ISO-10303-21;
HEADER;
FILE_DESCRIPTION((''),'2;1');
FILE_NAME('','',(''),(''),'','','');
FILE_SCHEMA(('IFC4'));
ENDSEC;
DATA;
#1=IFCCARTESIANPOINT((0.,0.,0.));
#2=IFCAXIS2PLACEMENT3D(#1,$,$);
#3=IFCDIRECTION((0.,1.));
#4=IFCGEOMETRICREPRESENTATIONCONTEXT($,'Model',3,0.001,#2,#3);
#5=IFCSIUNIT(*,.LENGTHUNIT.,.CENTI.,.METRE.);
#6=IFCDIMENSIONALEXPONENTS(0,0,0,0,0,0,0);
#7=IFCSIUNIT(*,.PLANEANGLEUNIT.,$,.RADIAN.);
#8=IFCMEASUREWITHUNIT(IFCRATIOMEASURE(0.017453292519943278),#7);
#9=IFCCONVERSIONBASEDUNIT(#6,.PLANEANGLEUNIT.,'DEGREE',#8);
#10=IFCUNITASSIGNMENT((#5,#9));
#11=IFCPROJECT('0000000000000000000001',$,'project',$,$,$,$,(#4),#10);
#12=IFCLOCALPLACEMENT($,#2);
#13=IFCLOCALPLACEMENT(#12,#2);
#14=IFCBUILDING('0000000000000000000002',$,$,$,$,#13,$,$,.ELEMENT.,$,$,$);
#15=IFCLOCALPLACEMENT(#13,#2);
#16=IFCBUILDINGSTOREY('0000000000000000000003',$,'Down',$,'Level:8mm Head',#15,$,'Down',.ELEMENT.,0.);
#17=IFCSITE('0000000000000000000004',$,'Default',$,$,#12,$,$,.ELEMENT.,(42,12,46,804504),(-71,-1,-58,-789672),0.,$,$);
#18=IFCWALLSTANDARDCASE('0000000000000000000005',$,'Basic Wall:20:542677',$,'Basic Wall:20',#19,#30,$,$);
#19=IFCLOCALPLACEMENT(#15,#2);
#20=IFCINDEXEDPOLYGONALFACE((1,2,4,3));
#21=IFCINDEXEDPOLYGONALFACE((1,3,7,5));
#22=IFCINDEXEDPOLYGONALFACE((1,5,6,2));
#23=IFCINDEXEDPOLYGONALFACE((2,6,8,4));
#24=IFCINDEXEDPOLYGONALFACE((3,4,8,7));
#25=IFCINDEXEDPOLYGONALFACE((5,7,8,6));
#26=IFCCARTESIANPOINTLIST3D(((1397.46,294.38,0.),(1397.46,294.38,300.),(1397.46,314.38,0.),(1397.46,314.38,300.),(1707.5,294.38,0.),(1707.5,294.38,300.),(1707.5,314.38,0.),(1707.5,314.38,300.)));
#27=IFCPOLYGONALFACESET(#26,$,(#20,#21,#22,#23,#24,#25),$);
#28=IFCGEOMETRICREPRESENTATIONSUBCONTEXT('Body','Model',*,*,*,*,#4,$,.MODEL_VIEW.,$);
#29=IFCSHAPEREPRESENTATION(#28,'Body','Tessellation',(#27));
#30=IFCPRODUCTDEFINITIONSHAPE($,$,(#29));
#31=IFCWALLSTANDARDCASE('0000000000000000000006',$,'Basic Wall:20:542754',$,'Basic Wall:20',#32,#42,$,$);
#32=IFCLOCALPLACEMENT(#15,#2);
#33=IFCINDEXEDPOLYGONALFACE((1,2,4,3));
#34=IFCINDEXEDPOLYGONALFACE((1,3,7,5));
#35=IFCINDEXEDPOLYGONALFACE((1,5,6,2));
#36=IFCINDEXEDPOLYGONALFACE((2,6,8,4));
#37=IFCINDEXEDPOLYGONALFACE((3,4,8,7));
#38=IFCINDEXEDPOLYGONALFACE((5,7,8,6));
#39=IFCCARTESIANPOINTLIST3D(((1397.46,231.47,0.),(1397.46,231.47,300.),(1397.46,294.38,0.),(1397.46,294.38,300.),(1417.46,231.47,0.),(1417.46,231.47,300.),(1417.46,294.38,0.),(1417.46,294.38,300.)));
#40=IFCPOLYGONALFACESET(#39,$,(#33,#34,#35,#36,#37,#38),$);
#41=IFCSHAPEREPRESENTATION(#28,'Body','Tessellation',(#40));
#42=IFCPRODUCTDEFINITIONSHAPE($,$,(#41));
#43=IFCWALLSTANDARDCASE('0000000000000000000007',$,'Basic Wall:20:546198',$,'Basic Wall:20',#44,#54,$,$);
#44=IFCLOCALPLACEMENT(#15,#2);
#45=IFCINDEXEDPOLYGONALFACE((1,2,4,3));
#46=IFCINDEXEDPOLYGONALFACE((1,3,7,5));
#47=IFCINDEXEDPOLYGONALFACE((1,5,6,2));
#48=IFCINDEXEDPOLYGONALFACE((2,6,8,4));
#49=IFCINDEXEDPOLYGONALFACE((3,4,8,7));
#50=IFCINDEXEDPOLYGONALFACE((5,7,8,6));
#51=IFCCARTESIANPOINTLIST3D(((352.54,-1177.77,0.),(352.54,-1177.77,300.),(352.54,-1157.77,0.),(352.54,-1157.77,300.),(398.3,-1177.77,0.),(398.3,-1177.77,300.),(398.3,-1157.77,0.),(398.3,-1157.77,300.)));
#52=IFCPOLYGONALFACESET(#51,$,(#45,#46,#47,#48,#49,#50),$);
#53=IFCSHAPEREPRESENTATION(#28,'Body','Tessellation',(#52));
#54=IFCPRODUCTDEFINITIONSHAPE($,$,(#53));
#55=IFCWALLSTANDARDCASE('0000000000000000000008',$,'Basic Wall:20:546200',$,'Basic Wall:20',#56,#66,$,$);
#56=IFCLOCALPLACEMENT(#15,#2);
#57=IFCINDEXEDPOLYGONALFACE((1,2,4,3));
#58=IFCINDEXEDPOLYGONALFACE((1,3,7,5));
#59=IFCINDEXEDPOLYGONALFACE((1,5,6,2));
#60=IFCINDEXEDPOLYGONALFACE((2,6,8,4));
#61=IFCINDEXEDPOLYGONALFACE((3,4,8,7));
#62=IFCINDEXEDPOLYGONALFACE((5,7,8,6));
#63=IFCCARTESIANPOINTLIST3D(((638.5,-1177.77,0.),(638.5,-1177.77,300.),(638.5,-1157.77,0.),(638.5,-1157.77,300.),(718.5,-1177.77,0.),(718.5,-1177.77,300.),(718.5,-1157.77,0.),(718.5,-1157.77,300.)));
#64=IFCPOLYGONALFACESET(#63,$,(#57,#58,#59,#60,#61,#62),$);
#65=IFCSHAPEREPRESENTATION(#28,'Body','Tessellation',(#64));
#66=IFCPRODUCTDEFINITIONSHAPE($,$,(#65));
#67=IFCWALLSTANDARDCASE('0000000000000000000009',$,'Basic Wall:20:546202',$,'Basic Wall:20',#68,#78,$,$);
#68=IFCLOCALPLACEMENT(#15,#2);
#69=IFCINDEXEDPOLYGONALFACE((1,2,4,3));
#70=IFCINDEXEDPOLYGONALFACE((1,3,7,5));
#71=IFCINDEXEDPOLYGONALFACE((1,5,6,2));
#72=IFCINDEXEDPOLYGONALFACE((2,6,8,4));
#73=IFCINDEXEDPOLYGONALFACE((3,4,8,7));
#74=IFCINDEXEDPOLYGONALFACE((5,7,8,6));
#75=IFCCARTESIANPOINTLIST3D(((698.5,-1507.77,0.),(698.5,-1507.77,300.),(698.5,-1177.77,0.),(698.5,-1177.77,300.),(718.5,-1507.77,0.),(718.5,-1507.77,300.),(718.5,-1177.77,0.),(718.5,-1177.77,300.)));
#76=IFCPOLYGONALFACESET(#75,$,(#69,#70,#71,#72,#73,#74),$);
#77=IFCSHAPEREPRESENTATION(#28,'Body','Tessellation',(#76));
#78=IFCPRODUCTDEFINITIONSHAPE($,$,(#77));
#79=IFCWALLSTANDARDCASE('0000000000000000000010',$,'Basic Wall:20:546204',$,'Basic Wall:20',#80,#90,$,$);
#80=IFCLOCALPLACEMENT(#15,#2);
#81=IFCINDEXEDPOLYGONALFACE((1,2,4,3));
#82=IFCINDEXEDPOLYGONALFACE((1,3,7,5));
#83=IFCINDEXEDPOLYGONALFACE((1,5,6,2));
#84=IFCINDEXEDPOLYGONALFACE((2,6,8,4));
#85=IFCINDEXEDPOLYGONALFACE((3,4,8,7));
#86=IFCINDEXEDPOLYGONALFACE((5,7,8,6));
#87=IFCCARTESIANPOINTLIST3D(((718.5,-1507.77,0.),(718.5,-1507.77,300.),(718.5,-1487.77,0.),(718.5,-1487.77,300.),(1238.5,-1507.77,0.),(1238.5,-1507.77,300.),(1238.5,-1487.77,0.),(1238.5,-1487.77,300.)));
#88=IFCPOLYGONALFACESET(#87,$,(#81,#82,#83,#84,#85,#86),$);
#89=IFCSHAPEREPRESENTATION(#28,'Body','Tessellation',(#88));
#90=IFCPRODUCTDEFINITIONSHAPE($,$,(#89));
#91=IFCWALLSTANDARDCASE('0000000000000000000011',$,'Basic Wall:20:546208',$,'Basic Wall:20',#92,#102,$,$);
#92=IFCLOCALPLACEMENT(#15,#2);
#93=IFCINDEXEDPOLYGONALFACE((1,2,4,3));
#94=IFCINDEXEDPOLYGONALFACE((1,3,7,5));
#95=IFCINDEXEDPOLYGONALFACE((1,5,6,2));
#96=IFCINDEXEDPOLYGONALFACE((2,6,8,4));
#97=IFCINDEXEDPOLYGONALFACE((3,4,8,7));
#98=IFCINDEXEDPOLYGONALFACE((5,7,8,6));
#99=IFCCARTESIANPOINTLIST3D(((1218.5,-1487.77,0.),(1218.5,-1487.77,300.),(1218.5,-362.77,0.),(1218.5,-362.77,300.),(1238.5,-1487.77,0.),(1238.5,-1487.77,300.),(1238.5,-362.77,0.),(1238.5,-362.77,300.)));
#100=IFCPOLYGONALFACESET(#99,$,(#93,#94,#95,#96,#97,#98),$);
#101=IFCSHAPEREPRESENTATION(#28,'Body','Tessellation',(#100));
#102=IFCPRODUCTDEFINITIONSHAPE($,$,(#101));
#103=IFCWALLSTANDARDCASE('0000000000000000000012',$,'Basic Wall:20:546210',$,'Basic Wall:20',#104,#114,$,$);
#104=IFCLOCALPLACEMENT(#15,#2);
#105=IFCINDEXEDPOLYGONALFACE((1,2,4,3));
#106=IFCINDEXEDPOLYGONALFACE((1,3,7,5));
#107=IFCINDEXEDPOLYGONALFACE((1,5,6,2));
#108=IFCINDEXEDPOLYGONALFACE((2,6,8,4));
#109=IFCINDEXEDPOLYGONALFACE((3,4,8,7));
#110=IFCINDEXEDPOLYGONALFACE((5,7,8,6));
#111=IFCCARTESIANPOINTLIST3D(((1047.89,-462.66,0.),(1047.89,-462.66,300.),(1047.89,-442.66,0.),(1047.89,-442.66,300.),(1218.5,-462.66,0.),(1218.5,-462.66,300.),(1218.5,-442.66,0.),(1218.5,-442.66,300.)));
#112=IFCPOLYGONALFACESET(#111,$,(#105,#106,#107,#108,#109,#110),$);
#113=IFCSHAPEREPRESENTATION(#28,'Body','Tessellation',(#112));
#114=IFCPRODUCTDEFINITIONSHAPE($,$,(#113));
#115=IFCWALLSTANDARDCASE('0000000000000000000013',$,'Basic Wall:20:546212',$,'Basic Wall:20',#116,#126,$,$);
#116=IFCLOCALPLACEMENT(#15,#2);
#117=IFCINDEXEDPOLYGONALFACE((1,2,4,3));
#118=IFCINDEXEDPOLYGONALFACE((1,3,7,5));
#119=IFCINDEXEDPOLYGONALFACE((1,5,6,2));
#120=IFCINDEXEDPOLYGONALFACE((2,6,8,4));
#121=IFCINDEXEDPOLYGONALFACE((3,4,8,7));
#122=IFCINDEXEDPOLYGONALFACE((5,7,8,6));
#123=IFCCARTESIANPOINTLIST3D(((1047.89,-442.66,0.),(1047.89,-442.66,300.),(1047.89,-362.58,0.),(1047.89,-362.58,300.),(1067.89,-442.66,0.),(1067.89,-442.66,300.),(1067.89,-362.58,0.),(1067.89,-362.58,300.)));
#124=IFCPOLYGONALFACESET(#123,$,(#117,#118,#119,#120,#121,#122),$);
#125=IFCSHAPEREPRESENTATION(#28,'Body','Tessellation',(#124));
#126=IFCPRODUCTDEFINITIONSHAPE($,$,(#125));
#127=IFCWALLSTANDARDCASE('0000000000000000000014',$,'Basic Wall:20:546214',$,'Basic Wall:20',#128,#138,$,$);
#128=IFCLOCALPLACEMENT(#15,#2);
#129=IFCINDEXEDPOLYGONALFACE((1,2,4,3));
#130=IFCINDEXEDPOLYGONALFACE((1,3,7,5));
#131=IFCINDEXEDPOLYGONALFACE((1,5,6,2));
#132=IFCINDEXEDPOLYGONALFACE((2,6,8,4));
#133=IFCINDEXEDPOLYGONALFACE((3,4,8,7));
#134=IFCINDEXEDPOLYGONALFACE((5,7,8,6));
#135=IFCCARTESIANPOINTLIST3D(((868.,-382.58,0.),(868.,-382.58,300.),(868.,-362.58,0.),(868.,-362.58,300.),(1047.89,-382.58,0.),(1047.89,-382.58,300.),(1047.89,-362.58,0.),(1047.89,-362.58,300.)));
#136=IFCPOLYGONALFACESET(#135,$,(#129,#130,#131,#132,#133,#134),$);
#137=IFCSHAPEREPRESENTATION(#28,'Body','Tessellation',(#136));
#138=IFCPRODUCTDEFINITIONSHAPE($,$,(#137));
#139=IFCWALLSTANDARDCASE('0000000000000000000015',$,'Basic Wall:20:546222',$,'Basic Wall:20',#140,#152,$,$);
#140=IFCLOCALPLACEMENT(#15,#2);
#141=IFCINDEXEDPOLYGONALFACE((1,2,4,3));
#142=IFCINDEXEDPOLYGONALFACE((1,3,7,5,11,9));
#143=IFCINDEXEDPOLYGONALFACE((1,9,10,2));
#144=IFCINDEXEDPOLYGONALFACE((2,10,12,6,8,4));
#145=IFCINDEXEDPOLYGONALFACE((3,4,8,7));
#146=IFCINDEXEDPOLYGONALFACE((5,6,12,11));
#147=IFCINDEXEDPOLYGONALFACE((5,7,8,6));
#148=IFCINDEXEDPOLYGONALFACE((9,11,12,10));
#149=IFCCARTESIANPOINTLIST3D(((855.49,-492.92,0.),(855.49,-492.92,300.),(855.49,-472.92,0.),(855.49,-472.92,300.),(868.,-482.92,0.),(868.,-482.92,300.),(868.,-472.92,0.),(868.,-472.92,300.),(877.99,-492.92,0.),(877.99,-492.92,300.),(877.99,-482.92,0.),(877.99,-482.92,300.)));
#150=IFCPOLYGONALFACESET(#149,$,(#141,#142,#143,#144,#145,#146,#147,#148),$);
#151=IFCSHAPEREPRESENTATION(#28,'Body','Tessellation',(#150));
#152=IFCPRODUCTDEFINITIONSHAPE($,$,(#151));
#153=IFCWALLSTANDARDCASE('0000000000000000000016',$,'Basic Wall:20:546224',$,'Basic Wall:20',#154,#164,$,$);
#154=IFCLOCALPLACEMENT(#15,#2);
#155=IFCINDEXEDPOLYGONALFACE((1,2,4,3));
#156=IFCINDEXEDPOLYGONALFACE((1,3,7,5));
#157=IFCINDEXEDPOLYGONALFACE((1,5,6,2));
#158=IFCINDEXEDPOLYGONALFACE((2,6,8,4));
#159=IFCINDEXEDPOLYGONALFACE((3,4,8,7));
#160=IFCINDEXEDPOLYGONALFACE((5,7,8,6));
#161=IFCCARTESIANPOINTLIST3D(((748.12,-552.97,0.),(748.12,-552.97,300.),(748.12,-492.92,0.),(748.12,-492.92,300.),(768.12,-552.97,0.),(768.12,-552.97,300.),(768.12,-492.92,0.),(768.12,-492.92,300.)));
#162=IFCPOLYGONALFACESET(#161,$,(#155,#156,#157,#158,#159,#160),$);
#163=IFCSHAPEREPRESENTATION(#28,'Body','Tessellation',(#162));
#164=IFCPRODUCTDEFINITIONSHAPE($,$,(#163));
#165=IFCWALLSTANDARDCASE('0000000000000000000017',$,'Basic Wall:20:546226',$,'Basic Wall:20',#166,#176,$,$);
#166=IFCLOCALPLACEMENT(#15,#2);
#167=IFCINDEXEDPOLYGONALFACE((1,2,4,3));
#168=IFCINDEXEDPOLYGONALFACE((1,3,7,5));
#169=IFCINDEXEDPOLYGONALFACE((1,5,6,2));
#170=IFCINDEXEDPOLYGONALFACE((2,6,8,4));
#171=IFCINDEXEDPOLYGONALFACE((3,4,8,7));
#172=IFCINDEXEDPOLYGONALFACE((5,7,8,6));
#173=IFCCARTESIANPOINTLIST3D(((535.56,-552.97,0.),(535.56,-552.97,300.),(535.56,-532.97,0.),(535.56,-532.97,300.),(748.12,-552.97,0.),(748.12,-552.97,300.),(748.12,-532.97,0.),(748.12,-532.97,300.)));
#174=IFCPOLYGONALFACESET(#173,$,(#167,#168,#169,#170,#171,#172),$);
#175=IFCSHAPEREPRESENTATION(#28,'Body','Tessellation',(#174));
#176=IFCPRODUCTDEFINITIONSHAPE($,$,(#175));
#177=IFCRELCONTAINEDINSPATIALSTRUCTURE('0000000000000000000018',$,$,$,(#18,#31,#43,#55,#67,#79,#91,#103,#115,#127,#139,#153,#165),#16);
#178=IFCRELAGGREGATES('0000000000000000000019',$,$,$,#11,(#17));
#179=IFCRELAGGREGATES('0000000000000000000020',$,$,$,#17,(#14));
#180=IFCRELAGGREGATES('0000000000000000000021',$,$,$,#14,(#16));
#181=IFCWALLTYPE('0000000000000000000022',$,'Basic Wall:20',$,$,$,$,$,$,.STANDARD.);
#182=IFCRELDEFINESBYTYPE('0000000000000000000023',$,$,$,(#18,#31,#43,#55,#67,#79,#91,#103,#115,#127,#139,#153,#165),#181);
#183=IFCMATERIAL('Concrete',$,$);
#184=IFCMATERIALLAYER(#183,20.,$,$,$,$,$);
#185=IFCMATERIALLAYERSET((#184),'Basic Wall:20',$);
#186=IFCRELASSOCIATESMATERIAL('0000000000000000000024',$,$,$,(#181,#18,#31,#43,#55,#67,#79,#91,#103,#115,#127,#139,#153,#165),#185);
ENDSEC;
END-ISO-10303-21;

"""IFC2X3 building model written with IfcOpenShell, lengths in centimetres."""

from ifc_helpers import new_model, entity, si_unit, converted_unit, direction, frame, frame_2d, origin, place, context, subcontext, project, spatial, polyline, rectangle, outline, extrude, material, layer, layer_set, layer_usage, type_object, element, save


model = new_model("IFC2X3")

# Units and contexts
model_context = context("Model", 3, precision=0.001, world=origin(), true_north=direction((0.0, 1.0)))
body_context = subcontext(model_context, "Body", "Model", "MODEL_VIEW")
ifc_project = project(units=[si_unit("LENGTHUNIT", "METRE", prefix="CENTI"), converted_unit("PLANEANGLEUNIT", "DEGREE", entity("IfcRatioMeasure", 0.017453292519943278), si_unit("PLANEANGLEUNIT", "RADIAN"), dimensions=[0, 0, 0, 0, 0, 0, 0])], contexts=[model_context])

# Site, building, storey
site_placement = place(None, origin())
site = spatial("IfcSite", under=ifc_project, at=site_placement, Name="Default", CompositionType="ELEMENT", RefLatitude=(42, 12, 46, 804504), RefLongitude=(-71, -1, -58, -789672), RefElevation=0.0)
building_placement = place(site_placement, origin())
building = spatial("IfcBuilding", under=site, at=building_placement, CompositionType="ELEMENT")
storey_placement = place(building_placement, origin())
storey = spatial("IfcBuildingStorey", under=building, at=storey_placement, Name="Down", ObjectType="Level:8mm Head", LongName="Down", CompositionType="ELEMENT", Elevation=0.0)

# Walls
ifc_material = material(Name="Concrete")
ifc_layer_1 = layer(ifc_material, 20.0)
ifc_layer_set_1 = layer_set([ifc_layer_1], Name="Basic Wall:20")
ifc_layer_usage_1 = layer_usage(ifc_layer_set_1, "AXIS2", "NEGATIVE", 10.0)
wall_type_1 = type_object("IfcWallType", Name="Basic Wall:20", PredefinedType="STANDARD", material=ifc_layer_set_1)
wall_1_placement = place(storey_placement, frame((1707.5, 304.38, 0.0), z_axis=(0.0, 0.0, 1.0), x_axis=(-1.0, 0.0, 0.0)))
element("IfcWallStandardCase", 1, at=wall_1_placement, inside=storey, type_object=wall_type_1, material=ifc_layer_usage_1, Name="Basic Wall:20:542677", ObjectType="Basic Wall:20", context=body_context, shape_type="SweptSolid", body=[
    extrude(rectangle(XDim=310.03, YDim=20.0, at=frame_2d((155.02, 0.0), x_axis=(-1.0, 0.0))), origin(), (0.0, 0.0, 1.0), 300.0),
])
ifc_layer_usage_2 = layer_usage(ifc_layer_set_1, "AXIS2", "POSITIVE", -10.0)
wall_2_placement = place(storey_placement, frame((1407.46, 294.38, 0.0), z_axis=(0.0, 0.0, 1.0), x_axis=(0.0, -1.0, 0.0)))
element("IfcWallStandardCase", 2, at=wall_2_placement, inside=storey, type_object=wall_type_1, material=ifc_layer_usage_2, Name="Basic Wall:20:542754", ObjectType="Basic Wall:20", context=body_context, shape_type="SweptSolid", body=[
    extrude(rectangle(XDim=62.91, YDim=20.0, at=frame_2d((31.45, 0.0), x_axis=(-1.0, 0.0))), origin(), (0.0, 0.0, 1.0), 300.0),
])
ifc_layer_usage_3 = layer_usage(ifc_layer_set_1, "AXIS2", "POSITIVE", -10.0)
wall_3_placement = place(storey_placement, frame((352.54, -1167.77, 0.0)))
element("IfcWallStandardCase", 3, at=wall_3_placement, inside=storey, type_object=wall_type_1, material=ifc_layer_usage_3, Name="Basic Wall:20:546198", ObjectType="Basic Wall:20", context=body_context, shape_type="SweptSolid", body=[
    extrude(rectangle(XDim=45.77, YDim=20.0, at=frame_2d((22.88, 0.0), x_axis=(-1.0, 0.0))), origin(), (0.0, 0.0, 1.0), 300.0),
])
ifc_layer_usage_4 = layer_usage(ifc_layer_set_1, "AXIS2", "POSITIVE", -10.0)
wall_4_placement = place(storey_placement, frame((638.5, -1167.77, 0.0)))
element("IfcWallStandardCase", 4, at=wall_4_placement, inside=storey, type_object=wall_type_1, material=ifc_layer_usage_4, Name="Basic Wall:20:546200", ObjectType="Basic Wall:20", context=body_context, shape_type="SweptSolid", body=[
    extrude(rectangle(XDim=80.0, YDim=20.0, at=frame_2d((40.0, 0.0), x_axis=(-1.0, 0.0))), origin(), (0.0, 0.0, 1.0), 300.0),
])
ifc_layer_usage_5 = layer_usage(ifc_layer_set_1, "AXIS2", "NEGATIVE", 10.0)
wall_5_placement = place(storey_placement, frame((708.5, -1177.77, 0.0), z_axis=(0.0, 0.0, 1.0), x_axis=(0.0, -1.0, 0.0)))
element("IfcWallStandardCase", 5, at=wall_5_placement, inside=storey, type_object=wall_type_1, material=ifc_layer_usage_5, Name="Basic Wall:20:546202", ObjectType="Basic Wall:20", context=body_context, shape_type="SweptSolid", body=[
    extrude(rectangle(XDim=330.0, YDim=20.0, at=frame_2d((165.0, 0.0), x_axis=(-1.0, 0.0))), origin(), (0.0, 0.0, 1.0), 300.0),
])
ifc_layer_usage_6 = layer_usage(ifc_layer_set_1, "AXIS2", "POSITIVE", -10.0)
wall_6_placement = place(storey_placement, frame((718.5, -1497.77, 0.0)))
element("IfcWallStandardCase", 6, at=wall_6_placement, inside=storey, type_object=wall_type_1, material=ifc_layer_usage_6, Name="Basic Wall:20:546204", ObjectType="Basic Wall:20", context=body_context, shape_type="SweptSolid", body=[
    extrude(rectangle(XDim=520.0, YDim=20.0, at=frame_2d((260.0, 0.0), x_axis=(-1.0, 0.0))), origin(), (0.0, 0.0, 1.0), 300.0),
])
ifc_layer_usage_7 = layer_usage(ifc_layer_set_1, "AXIS2", "POSITIVE", -10.0)
wall_7_placement = place(storey_placement, frame((1228.5, -1487.77, 0.0), z_axis=(0.0, 0.0, 1.0), x_axis=(0.0, 1.0, 0.0)))
element("IfcWallStandardCase", 7, at=wall_7_placement, inside=storey, type_object=wall_type_1, material=ifc_layer_usage_7, Name="Basic Wall:20:546208", ObjectType="Basic Wall:20", context=body_context, shape_type="SweptSolid", body=[
    extrude(rectangle(XDim=1125.0, YDim=20.0, at=frame_2d((562.5, 0.0), x_axis=(-1.0, 0.0))), origin(), (0.0, 0.0, 1.0), 300.0),
])
ifc_layer_usage_8 = layer_usage(ifc_layer_set_1, "AXIS2", "POSITIVE", -10.0)
wall_8_placement = place(storey_placement, frame((1047.89, -452.66, 0.0)))
element("IfcWallStandardCase", 8, at=wall_8_placement, inside=storey, type_object=wall_type_1, material=ifc_layer_usage_8, Name="Basic Wall:20:546210", ObjectType="Basic Wall:20", context=body_context, shape_type="SweptSolid", body=[
    extrude(rectangle(XDim=170.61, YDim=20.0, at=frame_2d((85.31, 0.0), x_axis=(-1.0, 0.0))), origin(), (0.0, 0.0, 1.0), 300.0),
])
ifc_layer_usage_9 = layer_usage(ifc_layer_set_1, "AXIS2", "NEGATIVE", 10.0)
wall_9_placement = place(storey_placement, frame((1057.89, -442.66, 0.0), z_axis=(0.0, 0.0, 1.0), x_axis=(0.0, 1.0, 0.0)))
element("IfcWallStandardCase", 9, at=wall_9_placement, inside=storey, type_object=wall_type_1, material=ifc_layer_usage_9, Name="Basic Wall:20:546212", ObjectType="Basic Wall:20", context=body_context, shape_type="SweptSolid", body=[
    extrude(rectangle(XDim=80.08, YDim=20.0, at=frame_2d((40.04, 0.0), x_axis=(-1.0, 0.0))), origin(), (0.0, 0.0, 1.0), 300.0),
])
ifc_layer_usage_10 = layer_usage(ifc_layer_set_1, "AXIS2", "POSITIVE", -10.0)
wall_10_placement = place(storey_placement, frame((1047.89, -372.58, 0.0), z_axis=(0.0, 0.0, 1.0), x_axis=(-1.0, 0.0, 0.0)))
element("IfcWallStandardCase", 10, at=wall_10_placement, inside=storey, type_object=wall_type_1, material=ifc_layer_usage_10, Name="Basic Wall:20:546214", ObjectType="Basic Wall:20", context=body_context, shape_type="SweptSolid", body=[
    extrude(rectangle(XDim=179.89, YDim=20.0, at=frame_2d((89.94, 0.0), x_axis=(-1.0, 0.0))), origin(), (0.0, 0.0, 1.0), 300.0),
])
ifc_layer_usage_11 = layer_usage(ifc_layer_set_1, "AXIS2", "NEGATIVE", 10.0)
wall_11_placement = place(storey_placement, frame((877.99, -482.92, 0.0), z_axis=(0.0, 0.0, 1.0), x_axis=(-1.0, 0.0, 0.0)))
element("IfcWallStandardCase", 11, at=wall_11_placement, inside=storey, type_object=wall_type_1, material=ifc_layer_usage_11, Name="Basic Wall:20:546222", ObjectType="Basic Wall:20", context=body_context, shape_type="SweptSolid", body=[
    extrude(outline(polyline([(22.5, -10.0), (22.5, 10.0), (0.0, 10.0), (0.0, 0.0), (9.99, 0.0), (9.99, -10.0), (22.5, -10.0)])), origin(), (0.0, 0.0, 1.0), 300.0),
])
ifc_layer_usage_12 = layer_usage(ifc_layer_set_1, "AXIS2", "POSITIVE", -10.0)
wall_12_placement = place(storey_placement, frame((758.12, -492.92, 0.0), z_axis=(0.0, 0.0, 1.0), x_axis=(0.0, -1.0, 0.0)))
element("IfcWallStandardCase", 12, at=wall_12_placement, inside=storey, type_object=wall_type_1, material=ifc_layer_usage_12, Name="Basic Wall:20:546224", ObjectType="Basic Wall:20", context=body_context, shape_type="SweptSolid", body=[
    extrude(rectangle(XDim=60.05, YDim=20.0, at=frame_2d((30.02, 0.0), x_axis=(-1.0, 0.0))), origin(), (0.0, 0.0, 1.0), 300.0),
])
ifc_layer_usage_13 = layer_usage(ifc_layer_set_1, "AXIS2", "NEGATIVE", 10.0)
wall_13_placement = place(storey_placement, frame((748.12, -542.97, 0.0), z_axis=(0.0, 0.0, 1.0), x_axis=(-1.0, 0.0, 0.0)))
element("IfcWallStandardCase", 13, at=wall_13_placement, inside=storey, type_object=wall_type_1, material=ifc_layer_usage_13, Name="Basic Wall:20:546226", ObjectType="Basic Wall:20", context=body_context, shape_type="SweptSolid", body=[
    extrude(rectangle(XDim=212.56, YDim=20.0, at=frame_2d((106.28, 0.0), x_axis=(-1.0, 0.0))), origin(), (0.0, 0.0, 1.0), 300.0),
])

save(model, "model.ifc")
